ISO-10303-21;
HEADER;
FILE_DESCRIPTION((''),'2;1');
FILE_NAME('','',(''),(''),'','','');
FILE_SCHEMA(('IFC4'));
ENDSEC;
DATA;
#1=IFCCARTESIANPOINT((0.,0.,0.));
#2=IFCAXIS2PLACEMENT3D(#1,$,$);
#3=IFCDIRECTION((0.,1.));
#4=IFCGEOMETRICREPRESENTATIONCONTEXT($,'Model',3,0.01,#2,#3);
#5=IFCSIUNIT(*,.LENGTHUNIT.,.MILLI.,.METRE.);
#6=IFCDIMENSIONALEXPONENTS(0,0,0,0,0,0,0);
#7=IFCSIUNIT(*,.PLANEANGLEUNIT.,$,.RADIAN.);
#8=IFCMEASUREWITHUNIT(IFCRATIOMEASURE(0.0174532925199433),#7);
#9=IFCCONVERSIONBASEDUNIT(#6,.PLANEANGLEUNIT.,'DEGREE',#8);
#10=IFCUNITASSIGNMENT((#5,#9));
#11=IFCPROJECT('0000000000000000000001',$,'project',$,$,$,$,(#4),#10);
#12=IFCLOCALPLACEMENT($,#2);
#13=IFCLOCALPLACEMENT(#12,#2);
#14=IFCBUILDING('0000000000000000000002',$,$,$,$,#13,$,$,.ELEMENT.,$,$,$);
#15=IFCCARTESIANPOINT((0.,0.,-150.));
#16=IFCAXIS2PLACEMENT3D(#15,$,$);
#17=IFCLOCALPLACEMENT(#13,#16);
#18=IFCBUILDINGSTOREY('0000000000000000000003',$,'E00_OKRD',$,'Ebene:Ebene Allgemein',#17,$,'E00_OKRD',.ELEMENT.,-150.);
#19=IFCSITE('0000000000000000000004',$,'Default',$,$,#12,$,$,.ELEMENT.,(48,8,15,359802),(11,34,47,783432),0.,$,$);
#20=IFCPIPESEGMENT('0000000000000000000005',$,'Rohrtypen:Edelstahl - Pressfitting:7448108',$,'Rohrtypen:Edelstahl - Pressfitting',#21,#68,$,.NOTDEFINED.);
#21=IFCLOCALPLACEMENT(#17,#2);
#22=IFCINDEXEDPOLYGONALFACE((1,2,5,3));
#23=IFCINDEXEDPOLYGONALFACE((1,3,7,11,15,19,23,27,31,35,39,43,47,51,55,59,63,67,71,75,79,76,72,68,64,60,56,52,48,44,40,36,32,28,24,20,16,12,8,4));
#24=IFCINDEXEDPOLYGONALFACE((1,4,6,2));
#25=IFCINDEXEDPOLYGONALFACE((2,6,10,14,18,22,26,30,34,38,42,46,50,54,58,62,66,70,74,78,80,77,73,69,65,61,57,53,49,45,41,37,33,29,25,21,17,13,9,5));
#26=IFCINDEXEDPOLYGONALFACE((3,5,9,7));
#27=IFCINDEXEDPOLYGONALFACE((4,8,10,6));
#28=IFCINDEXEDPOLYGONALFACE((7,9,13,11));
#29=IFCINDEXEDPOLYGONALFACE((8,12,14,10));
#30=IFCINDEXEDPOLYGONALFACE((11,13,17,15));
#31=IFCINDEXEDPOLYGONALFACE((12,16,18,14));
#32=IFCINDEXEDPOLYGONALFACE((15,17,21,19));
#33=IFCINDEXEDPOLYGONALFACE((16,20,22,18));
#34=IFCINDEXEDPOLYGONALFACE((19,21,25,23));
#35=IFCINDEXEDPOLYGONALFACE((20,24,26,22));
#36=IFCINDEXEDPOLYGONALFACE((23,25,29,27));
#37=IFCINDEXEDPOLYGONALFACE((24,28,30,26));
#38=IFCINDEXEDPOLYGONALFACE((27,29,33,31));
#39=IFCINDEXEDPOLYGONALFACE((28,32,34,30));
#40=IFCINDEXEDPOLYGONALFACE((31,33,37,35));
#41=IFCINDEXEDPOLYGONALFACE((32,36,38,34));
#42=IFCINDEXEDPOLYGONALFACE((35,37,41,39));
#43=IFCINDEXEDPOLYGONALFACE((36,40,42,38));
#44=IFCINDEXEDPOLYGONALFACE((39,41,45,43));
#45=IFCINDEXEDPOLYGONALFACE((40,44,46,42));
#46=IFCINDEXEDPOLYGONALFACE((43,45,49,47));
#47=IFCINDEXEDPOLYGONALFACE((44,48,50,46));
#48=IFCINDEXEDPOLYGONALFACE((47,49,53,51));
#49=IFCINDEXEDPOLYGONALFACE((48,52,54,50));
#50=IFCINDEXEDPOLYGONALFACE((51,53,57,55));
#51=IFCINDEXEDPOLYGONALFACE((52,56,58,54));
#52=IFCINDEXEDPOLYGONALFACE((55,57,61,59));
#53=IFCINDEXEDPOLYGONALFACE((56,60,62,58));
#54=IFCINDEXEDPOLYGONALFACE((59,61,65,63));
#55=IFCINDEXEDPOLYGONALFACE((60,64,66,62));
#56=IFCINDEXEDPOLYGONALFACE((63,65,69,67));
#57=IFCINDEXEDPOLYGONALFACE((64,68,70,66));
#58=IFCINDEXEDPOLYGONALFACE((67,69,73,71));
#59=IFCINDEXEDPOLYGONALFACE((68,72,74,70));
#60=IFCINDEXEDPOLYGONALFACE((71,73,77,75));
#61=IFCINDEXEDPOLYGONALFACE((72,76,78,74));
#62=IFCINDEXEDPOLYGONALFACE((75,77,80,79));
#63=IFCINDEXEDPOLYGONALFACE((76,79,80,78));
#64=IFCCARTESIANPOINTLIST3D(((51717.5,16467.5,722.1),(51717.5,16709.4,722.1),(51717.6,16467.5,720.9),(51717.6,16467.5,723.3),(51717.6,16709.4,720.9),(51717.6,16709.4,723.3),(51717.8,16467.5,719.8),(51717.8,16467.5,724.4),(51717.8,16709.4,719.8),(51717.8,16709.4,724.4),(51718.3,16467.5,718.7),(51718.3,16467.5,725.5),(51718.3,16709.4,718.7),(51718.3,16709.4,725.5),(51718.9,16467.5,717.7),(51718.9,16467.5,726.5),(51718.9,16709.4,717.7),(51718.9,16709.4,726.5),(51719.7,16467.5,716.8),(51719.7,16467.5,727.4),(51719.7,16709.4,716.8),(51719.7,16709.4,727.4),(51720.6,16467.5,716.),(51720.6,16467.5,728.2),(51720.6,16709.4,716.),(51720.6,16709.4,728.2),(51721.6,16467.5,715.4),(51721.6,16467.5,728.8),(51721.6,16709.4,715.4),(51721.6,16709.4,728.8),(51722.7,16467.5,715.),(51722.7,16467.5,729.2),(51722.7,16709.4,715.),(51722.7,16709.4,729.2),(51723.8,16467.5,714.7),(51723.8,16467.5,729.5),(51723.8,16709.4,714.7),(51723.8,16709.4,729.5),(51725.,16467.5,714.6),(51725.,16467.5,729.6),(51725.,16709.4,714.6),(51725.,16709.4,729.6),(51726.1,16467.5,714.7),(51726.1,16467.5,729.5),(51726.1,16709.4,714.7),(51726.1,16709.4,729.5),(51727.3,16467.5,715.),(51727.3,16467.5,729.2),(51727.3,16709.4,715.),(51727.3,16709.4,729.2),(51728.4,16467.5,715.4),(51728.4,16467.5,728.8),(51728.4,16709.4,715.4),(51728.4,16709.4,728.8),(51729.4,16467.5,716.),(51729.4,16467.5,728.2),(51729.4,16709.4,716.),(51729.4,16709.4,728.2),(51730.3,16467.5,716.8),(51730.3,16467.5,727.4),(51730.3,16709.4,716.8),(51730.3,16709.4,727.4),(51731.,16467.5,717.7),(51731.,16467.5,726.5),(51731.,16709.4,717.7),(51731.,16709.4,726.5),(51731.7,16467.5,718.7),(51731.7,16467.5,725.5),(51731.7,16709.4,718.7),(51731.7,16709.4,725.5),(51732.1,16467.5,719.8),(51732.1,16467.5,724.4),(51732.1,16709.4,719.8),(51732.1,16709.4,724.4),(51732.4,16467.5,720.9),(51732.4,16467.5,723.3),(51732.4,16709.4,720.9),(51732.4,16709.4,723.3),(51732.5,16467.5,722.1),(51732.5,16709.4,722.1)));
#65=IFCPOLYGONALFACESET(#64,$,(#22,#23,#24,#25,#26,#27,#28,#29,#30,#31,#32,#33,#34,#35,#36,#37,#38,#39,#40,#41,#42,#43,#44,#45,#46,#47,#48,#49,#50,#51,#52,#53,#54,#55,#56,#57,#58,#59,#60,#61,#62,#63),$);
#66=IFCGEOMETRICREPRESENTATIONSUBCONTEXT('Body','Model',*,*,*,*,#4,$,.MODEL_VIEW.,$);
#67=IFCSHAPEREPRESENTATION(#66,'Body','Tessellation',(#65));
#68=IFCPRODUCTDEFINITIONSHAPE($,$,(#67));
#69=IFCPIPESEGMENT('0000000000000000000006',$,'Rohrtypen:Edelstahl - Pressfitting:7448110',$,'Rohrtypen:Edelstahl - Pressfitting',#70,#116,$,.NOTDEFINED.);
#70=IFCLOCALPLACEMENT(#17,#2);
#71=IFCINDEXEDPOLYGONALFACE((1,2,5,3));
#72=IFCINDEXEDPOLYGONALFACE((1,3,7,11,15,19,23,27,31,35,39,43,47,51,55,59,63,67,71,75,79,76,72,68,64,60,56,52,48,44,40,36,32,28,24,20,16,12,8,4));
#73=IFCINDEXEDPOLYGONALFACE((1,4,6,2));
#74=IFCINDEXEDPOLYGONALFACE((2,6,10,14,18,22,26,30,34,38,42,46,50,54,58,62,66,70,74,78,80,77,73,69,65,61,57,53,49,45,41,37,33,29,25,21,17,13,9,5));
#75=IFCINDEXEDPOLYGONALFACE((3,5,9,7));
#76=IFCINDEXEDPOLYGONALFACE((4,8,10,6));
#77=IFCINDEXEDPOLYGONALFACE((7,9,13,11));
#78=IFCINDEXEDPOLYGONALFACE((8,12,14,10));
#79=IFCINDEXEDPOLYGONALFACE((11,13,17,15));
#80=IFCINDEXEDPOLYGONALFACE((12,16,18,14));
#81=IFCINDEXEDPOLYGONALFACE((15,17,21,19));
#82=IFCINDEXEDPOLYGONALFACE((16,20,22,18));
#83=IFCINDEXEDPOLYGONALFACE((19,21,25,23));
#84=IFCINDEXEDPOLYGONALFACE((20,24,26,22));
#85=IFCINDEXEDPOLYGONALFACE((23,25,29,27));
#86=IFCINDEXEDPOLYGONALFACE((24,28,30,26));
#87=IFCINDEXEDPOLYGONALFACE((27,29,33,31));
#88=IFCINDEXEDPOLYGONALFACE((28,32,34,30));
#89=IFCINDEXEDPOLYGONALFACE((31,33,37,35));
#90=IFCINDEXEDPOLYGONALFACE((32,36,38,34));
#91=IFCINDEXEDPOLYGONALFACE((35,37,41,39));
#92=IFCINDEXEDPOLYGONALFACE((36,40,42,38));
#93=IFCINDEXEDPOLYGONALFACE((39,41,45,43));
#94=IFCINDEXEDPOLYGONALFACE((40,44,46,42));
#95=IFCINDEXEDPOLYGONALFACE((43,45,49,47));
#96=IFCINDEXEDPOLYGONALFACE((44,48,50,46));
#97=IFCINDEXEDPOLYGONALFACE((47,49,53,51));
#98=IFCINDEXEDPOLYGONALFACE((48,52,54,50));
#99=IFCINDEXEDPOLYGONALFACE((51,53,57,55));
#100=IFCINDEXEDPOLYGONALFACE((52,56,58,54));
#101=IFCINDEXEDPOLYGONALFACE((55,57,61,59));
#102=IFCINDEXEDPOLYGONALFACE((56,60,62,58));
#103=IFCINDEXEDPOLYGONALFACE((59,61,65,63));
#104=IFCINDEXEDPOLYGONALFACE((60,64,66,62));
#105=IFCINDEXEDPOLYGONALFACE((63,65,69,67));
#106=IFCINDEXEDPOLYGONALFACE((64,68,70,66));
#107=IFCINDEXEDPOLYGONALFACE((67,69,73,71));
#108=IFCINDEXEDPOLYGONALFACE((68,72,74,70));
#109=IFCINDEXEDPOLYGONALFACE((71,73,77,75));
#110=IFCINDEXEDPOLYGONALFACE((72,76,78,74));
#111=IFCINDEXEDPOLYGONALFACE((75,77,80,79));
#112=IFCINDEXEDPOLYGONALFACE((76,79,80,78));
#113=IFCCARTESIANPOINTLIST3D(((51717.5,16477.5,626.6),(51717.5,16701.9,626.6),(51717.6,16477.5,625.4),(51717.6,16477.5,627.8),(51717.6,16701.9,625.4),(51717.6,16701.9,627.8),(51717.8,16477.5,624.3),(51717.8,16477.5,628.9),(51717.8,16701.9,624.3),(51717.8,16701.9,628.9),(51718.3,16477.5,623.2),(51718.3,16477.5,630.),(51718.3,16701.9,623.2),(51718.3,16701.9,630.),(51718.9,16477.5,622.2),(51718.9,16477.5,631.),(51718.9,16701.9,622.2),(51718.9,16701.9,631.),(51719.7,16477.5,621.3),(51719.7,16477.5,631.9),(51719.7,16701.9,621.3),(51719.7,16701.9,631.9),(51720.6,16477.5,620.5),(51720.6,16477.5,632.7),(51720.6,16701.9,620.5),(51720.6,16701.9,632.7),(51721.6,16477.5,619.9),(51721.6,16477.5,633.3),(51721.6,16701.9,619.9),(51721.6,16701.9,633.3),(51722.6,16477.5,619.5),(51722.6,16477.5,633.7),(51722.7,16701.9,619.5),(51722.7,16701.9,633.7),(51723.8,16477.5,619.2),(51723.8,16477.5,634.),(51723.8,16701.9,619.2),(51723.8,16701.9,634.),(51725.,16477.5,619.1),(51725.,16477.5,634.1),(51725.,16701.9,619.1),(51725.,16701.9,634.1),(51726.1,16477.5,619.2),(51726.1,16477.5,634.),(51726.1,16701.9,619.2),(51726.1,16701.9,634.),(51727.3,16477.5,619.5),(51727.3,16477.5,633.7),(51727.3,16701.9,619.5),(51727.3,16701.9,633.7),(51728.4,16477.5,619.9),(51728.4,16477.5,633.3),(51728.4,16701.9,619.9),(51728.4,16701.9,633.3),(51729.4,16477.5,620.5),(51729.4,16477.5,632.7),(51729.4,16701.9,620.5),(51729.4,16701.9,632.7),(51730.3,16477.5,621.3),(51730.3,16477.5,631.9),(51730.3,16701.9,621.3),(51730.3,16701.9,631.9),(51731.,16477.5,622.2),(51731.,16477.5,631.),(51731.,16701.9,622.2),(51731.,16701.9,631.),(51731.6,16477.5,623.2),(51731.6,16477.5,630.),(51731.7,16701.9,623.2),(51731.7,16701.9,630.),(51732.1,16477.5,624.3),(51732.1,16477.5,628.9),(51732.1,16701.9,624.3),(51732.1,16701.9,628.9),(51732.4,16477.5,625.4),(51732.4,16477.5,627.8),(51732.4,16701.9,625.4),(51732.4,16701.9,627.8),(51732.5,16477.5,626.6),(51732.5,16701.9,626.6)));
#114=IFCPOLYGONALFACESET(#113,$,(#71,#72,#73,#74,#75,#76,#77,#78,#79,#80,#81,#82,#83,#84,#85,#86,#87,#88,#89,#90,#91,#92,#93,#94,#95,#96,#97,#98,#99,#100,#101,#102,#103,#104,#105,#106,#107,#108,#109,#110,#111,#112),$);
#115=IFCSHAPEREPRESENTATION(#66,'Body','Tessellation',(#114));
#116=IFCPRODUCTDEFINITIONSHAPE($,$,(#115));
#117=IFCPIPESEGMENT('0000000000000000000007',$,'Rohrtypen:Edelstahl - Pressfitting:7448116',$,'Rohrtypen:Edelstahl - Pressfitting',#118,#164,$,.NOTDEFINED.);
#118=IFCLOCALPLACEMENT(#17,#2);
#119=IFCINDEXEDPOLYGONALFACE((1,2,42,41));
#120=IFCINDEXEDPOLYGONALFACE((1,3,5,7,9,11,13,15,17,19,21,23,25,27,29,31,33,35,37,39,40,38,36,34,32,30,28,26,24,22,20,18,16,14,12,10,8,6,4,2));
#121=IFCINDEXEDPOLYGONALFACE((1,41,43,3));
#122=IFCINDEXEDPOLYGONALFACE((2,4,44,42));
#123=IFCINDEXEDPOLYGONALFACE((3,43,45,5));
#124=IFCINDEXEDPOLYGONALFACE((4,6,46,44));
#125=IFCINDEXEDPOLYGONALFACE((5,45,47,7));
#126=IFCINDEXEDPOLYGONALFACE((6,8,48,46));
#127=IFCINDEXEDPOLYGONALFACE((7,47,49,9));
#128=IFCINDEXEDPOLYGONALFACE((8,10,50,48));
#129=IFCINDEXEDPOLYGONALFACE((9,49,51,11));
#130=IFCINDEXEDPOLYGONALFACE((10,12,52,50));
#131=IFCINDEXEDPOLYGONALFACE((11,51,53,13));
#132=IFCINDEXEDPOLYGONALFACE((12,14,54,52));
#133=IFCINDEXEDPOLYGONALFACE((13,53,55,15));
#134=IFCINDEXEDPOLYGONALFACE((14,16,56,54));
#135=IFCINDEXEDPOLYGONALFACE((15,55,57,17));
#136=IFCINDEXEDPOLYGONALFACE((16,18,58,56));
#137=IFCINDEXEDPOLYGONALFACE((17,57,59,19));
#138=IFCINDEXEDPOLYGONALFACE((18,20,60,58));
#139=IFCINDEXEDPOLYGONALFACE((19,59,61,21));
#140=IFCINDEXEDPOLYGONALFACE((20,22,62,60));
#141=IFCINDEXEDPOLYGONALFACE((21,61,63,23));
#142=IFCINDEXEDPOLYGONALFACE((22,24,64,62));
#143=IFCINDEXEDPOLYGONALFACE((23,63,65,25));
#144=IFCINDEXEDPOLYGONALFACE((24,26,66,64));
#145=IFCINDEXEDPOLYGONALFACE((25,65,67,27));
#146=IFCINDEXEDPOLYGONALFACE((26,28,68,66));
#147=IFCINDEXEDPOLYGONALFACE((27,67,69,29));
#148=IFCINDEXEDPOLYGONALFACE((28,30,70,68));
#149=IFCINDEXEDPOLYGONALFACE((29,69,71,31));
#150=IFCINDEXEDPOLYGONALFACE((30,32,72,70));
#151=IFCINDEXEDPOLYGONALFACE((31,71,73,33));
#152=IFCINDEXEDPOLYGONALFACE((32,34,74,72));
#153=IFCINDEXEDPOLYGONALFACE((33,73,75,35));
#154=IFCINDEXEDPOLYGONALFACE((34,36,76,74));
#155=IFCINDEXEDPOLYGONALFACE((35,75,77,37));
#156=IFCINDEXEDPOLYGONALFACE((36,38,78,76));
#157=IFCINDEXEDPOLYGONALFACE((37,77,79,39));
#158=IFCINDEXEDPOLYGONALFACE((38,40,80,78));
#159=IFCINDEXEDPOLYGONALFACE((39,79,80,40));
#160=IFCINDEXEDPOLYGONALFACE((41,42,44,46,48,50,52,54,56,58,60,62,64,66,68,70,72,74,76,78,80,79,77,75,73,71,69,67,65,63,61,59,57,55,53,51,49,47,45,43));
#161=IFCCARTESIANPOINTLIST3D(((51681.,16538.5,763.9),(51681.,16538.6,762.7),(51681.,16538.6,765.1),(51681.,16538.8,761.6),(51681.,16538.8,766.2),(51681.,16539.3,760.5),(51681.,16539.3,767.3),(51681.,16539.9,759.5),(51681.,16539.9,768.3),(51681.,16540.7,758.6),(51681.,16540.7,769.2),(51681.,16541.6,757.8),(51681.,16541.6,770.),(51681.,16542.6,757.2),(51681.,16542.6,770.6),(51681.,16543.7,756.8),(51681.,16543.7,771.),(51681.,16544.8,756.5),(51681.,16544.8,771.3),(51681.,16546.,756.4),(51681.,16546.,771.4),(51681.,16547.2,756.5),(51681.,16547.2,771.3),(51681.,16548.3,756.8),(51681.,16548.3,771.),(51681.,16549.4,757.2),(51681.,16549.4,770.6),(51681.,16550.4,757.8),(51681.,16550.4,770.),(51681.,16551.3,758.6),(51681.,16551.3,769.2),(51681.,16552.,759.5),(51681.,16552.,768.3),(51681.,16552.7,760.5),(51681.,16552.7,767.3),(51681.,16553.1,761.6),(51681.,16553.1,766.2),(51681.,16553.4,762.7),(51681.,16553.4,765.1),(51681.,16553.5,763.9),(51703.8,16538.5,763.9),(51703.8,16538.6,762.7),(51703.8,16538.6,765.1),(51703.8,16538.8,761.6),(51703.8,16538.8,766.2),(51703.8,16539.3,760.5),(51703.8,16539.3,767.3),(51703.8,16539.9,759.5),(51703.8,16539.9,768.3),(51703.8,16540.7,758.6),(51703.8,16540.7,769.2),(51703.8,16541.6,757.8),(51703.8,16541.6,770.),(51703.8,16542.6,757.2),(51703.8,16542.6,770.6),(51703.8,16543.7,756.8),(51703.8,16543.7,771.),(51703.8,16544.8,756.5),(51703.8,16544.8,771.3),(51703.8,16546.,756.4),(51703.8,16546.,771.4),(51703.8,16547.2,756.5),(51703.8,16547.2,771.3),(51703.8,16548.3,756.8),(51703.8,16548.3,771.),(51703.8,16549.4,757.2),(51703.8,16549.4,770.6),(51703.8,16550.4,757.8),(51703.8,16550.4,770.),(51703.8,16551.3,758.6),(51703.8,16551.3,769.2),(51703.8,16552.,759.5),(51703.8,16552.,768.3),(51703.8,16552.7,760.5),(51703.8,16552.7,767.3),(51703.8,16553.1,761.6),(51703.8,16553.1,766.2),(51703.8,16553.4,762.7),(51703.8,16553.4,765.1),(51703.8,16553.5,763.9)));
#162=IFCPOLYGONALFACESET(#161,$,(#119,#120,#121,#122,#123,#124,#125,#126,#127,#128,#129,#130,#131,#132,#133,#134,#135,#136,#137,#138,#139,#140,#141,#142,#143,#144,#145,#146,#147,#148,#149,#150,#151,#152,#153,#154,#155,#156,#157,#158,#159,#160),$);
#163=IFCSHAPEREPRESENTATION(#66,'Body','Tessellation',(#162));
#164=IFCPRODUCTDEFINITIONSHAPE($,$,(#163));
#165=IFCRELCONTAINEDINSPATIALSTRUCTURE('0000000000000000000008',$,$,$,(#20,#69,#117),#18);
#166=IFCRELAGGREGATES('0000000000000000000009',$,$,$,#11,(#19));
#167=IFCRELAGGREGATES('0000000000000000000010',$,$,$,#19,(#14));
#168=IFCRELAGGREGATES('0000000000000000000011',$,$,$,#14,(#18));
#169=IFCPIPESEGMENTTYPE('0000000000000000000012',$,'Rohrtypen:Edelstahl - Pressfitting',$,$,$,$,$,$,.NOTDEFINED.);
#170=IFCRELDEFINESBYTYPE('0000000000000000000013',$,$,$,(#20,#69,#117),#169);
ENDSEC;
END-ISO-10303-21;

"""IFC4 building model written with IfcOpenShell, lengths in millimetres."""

from ifc_helpers import new_model, entity, si_unit, converted_unit, direction, frame, origin, place, context, subcontext, project, spatial, indexed_curve, outline, extrude, type_object, element, save


model = new_model("IFC4")

# Units and contexts
model_context = context("Model", 3, precision=0.01, world=origin(), true_north=direction((0.0, 1.0)))
body_context = subcontext(model_context, "Body", "Model", "MODEL_VIEW")
ifc_project = project(units=[si_unit("LENGTHUNIT", "METRE", prefix="MILLI"), converted_unit("PLANEANGLEUNIT", "DEGREE", entity("IfcRatioMeasure", 0.0174532925199433), si_unit("PLANEANGLEUNIT", "RADIAN"), dimensions=[0, 0, 0, 0, 0, 0, 0])], contexts=[model_context])

# Site, building, storey
site_placement = place(None, origin())
site = spatial("IfcSite", under=ifc_project, at=site_placement, Name="Default", CompositionType="ELEMENT", RefLatitude=(48, 8, 15, 359802), RefLongitude=(11, 34, 47, 783432), RefElevation=0.0)
building_placement = place(site_placement, origin())
building = spatial("IfcBuilding", under=site, at=building_placement, CompositionType="ELEMENT")
storey_placement = place(building_placement, frame((0.0, 0.0, -150.0)))
storey = spatial("IfcBuildingStorey", under=building, at=storey_placement, Name="E00_OKRD", ObjectType="Ebene:Ebene Allgemein", LongName="E00_OKRD", CompositionType="ELEMENT", Elevation=-150.0)

# Pipe segments
pipe_segment_type_1 = type_object("IfcPipeSegmentType", Name="Rohrtypen:Edelstahl - Pressfitting", PredefinedType="NOTDEFINED")
pipe_segment_1_placement = place(storey_placement, origin())
element("IfcPipeSegment", 1, at=pipe_segment_1_placement, inside=storey, type_object=pipe_segment_type_1, Name="Rohrtypen:Edelstahl - Pressfitting:7448108", ObjectType="Rohrtypen:Edelstahl - Pressfitting", PredefinedType="NOTDEFINED", context=body_context, shape_type="SweptSolid", body=[
    extrude(outline(indexed_curve([(7.5, 0.0), (7.4, 1.2), (7.1, 2.3), (6.7, 3.4), (6.1, 4.4), (5.3, 5.3), (4.4, 6.1), (3.4, 6.7), (2.3, 7.1), (1.2, 7.4), (0.0, 7.5), (-1.2, 7.4), (-2.3, 7.1), (-3.4, 6.7), (-4.4, 6.1), (-5.3, 5.3), (-6.1, 4.4), (-6.7, 3.4), (-7.1, 2.3), (-7.4, 1.2), (-7.5, 0.0), (-7.4, -1.2), (-7.1, -2.3), (-6.7, -3.4), (-6.1, -4.4), (-5.3, -5.3), (-4.4, -6.1), (-3.4, -6.7), (-2.3, -7.1), (-1.2, -7.4), (0.0, -7.5), (1.2, -7.4), (2.3, -7.1), (3.4, -6.7), (4.4, -6.1), (5.3, -5.3), (6.1, -4.4), (6.7, -3.4), (7.1, -2.3), (7.4, -1.2), (7.5, 0.0)], self_intersect=False)), frame((51725.0, 16467.5, 722.1), z_axis=(0.0, 1.0, 0.0), x_axis=(1.0, 0.0, 0.0)), (0.0, 0.0, 1.0), 241.9),
])
pipe_segment_2_placement = place(storey_placement, origin())
element("IfcPipeSegment", 2, at=pipe_segment_2_placement, inside=storey, type_object=pipe_segment_type_1, Name="Rohrtypen:Edelstahl - Pressfitting:7448110", ObjectType="Rohrtypen:Edelstahl - Pressfitting", PredefinedType="NOTDEFINED", context=body_context, shape_type="SweptSolid", body=[
    extrude(outline(indexed_curve([(7.5, 0.0), (7.4, 1.2), (7.1, 2.3), (6.7, 3.4), (6.1, 4.4), (5.3, 5.3), (4.4, 6.1), (3.4, 6.7), (2.3, 7.1), (1.2, 7.4), (0.0, 7.5), (-1.2, 7.4), (-2.3, 7.1), (-3.4, 6.7), (-4.4, 6.1), (-5.3, 5.3), (-6.1, 4.4), (-6.7, 3.4), (-7.1, 2.3), (-7.4, 1.2), (-7.5, 0.0), (-7.4, -1.2), (-7.1, -2.3), (-6.7, -3.4), (-6.1, -4.4), (-5.3, -5.3), (-4.4, -6.1), (-3.4, -6.7), (-2.3, -7.1), (-1.2, -7.4), (0.0, -7.5), (1.2, -7.4), (2.3, -7.1), (3.4, -6.7), (4.4, -6.1), (5.3, -5.3), (6.1, -4.4), (6.7, -3.4), (7.1, -2.3), (7.4, -1.2), (7.5, 0.0)], self_intersect=False)), frame((51725.0, 16477.5, 626.6), z_axis=(0.000016, 1.0, 0.0), x_axis=(1.0, -0.000016, 0.0)), (0.0, 0.0, 1.0), 224.4),
])
pipe_segment_3_placement = place(storey_placement, origin())
element("IfcPipeSegment", 3, at=pipe_segment_3_placement, inside=storey, type_object=pipe_segment_type_1, Name="Rohrtypen:Edelstahl - Pressfitting:7448116", ObjectType="Rohrtypen:Edelstahl - Pressfitting", PredefinedType="NOTDEFINED", context=body_context, shape_type="SweptSolid", body=[
    extrude(outline(indexed_curve([(7.5, 0.0), (7.4, 1.2), (7.1, 2.3), (6.7, 3.4), (6.1, 4.4), (5.3, 5.3), (4.4, 6.1), (3.4, 6.7), (2.3, 7.1), (1.2, 7.4), (0.0, 7.5), (-1.2, 7.4), (-2.3, 7.1), (-3.4, 6.7), (-4.4, 6.1), (-5.3, 5.3), (-6.1, 4.4), (-6.7, 3.4), (-7.1, 2.3), (-7.4, 1.2), (-7.5, 0.0), (-7.4, -1.2), (-7.1, -2.3), (-6.7, -3.4), (-6.1, -4.4), (-5.3, -5.3), (-4.4, -6.1), (-3.4, -6.7), (-2.3, -7.1), (-1.2, -7.4), (0.0, -7.5), (1.2, -7.4), (2.3, -7.1), (3.4, -6.7), (4.4, -6.1), (5.3, -5.3), (6.1, -4.4), (6.7, -3.4), (7.1, -2.3), (7.4, -1.2), (7.5, 0.0)], self_intersect=False)), frame((51681.0, 16546.0, 763.9), z_axis=(1.0, 0.0, 0.0), x_axis=(0.0, -1.0, 0.0)), (0.0, 0.0, 1.0), 22.8),
])

save(model, "model.ifc")
